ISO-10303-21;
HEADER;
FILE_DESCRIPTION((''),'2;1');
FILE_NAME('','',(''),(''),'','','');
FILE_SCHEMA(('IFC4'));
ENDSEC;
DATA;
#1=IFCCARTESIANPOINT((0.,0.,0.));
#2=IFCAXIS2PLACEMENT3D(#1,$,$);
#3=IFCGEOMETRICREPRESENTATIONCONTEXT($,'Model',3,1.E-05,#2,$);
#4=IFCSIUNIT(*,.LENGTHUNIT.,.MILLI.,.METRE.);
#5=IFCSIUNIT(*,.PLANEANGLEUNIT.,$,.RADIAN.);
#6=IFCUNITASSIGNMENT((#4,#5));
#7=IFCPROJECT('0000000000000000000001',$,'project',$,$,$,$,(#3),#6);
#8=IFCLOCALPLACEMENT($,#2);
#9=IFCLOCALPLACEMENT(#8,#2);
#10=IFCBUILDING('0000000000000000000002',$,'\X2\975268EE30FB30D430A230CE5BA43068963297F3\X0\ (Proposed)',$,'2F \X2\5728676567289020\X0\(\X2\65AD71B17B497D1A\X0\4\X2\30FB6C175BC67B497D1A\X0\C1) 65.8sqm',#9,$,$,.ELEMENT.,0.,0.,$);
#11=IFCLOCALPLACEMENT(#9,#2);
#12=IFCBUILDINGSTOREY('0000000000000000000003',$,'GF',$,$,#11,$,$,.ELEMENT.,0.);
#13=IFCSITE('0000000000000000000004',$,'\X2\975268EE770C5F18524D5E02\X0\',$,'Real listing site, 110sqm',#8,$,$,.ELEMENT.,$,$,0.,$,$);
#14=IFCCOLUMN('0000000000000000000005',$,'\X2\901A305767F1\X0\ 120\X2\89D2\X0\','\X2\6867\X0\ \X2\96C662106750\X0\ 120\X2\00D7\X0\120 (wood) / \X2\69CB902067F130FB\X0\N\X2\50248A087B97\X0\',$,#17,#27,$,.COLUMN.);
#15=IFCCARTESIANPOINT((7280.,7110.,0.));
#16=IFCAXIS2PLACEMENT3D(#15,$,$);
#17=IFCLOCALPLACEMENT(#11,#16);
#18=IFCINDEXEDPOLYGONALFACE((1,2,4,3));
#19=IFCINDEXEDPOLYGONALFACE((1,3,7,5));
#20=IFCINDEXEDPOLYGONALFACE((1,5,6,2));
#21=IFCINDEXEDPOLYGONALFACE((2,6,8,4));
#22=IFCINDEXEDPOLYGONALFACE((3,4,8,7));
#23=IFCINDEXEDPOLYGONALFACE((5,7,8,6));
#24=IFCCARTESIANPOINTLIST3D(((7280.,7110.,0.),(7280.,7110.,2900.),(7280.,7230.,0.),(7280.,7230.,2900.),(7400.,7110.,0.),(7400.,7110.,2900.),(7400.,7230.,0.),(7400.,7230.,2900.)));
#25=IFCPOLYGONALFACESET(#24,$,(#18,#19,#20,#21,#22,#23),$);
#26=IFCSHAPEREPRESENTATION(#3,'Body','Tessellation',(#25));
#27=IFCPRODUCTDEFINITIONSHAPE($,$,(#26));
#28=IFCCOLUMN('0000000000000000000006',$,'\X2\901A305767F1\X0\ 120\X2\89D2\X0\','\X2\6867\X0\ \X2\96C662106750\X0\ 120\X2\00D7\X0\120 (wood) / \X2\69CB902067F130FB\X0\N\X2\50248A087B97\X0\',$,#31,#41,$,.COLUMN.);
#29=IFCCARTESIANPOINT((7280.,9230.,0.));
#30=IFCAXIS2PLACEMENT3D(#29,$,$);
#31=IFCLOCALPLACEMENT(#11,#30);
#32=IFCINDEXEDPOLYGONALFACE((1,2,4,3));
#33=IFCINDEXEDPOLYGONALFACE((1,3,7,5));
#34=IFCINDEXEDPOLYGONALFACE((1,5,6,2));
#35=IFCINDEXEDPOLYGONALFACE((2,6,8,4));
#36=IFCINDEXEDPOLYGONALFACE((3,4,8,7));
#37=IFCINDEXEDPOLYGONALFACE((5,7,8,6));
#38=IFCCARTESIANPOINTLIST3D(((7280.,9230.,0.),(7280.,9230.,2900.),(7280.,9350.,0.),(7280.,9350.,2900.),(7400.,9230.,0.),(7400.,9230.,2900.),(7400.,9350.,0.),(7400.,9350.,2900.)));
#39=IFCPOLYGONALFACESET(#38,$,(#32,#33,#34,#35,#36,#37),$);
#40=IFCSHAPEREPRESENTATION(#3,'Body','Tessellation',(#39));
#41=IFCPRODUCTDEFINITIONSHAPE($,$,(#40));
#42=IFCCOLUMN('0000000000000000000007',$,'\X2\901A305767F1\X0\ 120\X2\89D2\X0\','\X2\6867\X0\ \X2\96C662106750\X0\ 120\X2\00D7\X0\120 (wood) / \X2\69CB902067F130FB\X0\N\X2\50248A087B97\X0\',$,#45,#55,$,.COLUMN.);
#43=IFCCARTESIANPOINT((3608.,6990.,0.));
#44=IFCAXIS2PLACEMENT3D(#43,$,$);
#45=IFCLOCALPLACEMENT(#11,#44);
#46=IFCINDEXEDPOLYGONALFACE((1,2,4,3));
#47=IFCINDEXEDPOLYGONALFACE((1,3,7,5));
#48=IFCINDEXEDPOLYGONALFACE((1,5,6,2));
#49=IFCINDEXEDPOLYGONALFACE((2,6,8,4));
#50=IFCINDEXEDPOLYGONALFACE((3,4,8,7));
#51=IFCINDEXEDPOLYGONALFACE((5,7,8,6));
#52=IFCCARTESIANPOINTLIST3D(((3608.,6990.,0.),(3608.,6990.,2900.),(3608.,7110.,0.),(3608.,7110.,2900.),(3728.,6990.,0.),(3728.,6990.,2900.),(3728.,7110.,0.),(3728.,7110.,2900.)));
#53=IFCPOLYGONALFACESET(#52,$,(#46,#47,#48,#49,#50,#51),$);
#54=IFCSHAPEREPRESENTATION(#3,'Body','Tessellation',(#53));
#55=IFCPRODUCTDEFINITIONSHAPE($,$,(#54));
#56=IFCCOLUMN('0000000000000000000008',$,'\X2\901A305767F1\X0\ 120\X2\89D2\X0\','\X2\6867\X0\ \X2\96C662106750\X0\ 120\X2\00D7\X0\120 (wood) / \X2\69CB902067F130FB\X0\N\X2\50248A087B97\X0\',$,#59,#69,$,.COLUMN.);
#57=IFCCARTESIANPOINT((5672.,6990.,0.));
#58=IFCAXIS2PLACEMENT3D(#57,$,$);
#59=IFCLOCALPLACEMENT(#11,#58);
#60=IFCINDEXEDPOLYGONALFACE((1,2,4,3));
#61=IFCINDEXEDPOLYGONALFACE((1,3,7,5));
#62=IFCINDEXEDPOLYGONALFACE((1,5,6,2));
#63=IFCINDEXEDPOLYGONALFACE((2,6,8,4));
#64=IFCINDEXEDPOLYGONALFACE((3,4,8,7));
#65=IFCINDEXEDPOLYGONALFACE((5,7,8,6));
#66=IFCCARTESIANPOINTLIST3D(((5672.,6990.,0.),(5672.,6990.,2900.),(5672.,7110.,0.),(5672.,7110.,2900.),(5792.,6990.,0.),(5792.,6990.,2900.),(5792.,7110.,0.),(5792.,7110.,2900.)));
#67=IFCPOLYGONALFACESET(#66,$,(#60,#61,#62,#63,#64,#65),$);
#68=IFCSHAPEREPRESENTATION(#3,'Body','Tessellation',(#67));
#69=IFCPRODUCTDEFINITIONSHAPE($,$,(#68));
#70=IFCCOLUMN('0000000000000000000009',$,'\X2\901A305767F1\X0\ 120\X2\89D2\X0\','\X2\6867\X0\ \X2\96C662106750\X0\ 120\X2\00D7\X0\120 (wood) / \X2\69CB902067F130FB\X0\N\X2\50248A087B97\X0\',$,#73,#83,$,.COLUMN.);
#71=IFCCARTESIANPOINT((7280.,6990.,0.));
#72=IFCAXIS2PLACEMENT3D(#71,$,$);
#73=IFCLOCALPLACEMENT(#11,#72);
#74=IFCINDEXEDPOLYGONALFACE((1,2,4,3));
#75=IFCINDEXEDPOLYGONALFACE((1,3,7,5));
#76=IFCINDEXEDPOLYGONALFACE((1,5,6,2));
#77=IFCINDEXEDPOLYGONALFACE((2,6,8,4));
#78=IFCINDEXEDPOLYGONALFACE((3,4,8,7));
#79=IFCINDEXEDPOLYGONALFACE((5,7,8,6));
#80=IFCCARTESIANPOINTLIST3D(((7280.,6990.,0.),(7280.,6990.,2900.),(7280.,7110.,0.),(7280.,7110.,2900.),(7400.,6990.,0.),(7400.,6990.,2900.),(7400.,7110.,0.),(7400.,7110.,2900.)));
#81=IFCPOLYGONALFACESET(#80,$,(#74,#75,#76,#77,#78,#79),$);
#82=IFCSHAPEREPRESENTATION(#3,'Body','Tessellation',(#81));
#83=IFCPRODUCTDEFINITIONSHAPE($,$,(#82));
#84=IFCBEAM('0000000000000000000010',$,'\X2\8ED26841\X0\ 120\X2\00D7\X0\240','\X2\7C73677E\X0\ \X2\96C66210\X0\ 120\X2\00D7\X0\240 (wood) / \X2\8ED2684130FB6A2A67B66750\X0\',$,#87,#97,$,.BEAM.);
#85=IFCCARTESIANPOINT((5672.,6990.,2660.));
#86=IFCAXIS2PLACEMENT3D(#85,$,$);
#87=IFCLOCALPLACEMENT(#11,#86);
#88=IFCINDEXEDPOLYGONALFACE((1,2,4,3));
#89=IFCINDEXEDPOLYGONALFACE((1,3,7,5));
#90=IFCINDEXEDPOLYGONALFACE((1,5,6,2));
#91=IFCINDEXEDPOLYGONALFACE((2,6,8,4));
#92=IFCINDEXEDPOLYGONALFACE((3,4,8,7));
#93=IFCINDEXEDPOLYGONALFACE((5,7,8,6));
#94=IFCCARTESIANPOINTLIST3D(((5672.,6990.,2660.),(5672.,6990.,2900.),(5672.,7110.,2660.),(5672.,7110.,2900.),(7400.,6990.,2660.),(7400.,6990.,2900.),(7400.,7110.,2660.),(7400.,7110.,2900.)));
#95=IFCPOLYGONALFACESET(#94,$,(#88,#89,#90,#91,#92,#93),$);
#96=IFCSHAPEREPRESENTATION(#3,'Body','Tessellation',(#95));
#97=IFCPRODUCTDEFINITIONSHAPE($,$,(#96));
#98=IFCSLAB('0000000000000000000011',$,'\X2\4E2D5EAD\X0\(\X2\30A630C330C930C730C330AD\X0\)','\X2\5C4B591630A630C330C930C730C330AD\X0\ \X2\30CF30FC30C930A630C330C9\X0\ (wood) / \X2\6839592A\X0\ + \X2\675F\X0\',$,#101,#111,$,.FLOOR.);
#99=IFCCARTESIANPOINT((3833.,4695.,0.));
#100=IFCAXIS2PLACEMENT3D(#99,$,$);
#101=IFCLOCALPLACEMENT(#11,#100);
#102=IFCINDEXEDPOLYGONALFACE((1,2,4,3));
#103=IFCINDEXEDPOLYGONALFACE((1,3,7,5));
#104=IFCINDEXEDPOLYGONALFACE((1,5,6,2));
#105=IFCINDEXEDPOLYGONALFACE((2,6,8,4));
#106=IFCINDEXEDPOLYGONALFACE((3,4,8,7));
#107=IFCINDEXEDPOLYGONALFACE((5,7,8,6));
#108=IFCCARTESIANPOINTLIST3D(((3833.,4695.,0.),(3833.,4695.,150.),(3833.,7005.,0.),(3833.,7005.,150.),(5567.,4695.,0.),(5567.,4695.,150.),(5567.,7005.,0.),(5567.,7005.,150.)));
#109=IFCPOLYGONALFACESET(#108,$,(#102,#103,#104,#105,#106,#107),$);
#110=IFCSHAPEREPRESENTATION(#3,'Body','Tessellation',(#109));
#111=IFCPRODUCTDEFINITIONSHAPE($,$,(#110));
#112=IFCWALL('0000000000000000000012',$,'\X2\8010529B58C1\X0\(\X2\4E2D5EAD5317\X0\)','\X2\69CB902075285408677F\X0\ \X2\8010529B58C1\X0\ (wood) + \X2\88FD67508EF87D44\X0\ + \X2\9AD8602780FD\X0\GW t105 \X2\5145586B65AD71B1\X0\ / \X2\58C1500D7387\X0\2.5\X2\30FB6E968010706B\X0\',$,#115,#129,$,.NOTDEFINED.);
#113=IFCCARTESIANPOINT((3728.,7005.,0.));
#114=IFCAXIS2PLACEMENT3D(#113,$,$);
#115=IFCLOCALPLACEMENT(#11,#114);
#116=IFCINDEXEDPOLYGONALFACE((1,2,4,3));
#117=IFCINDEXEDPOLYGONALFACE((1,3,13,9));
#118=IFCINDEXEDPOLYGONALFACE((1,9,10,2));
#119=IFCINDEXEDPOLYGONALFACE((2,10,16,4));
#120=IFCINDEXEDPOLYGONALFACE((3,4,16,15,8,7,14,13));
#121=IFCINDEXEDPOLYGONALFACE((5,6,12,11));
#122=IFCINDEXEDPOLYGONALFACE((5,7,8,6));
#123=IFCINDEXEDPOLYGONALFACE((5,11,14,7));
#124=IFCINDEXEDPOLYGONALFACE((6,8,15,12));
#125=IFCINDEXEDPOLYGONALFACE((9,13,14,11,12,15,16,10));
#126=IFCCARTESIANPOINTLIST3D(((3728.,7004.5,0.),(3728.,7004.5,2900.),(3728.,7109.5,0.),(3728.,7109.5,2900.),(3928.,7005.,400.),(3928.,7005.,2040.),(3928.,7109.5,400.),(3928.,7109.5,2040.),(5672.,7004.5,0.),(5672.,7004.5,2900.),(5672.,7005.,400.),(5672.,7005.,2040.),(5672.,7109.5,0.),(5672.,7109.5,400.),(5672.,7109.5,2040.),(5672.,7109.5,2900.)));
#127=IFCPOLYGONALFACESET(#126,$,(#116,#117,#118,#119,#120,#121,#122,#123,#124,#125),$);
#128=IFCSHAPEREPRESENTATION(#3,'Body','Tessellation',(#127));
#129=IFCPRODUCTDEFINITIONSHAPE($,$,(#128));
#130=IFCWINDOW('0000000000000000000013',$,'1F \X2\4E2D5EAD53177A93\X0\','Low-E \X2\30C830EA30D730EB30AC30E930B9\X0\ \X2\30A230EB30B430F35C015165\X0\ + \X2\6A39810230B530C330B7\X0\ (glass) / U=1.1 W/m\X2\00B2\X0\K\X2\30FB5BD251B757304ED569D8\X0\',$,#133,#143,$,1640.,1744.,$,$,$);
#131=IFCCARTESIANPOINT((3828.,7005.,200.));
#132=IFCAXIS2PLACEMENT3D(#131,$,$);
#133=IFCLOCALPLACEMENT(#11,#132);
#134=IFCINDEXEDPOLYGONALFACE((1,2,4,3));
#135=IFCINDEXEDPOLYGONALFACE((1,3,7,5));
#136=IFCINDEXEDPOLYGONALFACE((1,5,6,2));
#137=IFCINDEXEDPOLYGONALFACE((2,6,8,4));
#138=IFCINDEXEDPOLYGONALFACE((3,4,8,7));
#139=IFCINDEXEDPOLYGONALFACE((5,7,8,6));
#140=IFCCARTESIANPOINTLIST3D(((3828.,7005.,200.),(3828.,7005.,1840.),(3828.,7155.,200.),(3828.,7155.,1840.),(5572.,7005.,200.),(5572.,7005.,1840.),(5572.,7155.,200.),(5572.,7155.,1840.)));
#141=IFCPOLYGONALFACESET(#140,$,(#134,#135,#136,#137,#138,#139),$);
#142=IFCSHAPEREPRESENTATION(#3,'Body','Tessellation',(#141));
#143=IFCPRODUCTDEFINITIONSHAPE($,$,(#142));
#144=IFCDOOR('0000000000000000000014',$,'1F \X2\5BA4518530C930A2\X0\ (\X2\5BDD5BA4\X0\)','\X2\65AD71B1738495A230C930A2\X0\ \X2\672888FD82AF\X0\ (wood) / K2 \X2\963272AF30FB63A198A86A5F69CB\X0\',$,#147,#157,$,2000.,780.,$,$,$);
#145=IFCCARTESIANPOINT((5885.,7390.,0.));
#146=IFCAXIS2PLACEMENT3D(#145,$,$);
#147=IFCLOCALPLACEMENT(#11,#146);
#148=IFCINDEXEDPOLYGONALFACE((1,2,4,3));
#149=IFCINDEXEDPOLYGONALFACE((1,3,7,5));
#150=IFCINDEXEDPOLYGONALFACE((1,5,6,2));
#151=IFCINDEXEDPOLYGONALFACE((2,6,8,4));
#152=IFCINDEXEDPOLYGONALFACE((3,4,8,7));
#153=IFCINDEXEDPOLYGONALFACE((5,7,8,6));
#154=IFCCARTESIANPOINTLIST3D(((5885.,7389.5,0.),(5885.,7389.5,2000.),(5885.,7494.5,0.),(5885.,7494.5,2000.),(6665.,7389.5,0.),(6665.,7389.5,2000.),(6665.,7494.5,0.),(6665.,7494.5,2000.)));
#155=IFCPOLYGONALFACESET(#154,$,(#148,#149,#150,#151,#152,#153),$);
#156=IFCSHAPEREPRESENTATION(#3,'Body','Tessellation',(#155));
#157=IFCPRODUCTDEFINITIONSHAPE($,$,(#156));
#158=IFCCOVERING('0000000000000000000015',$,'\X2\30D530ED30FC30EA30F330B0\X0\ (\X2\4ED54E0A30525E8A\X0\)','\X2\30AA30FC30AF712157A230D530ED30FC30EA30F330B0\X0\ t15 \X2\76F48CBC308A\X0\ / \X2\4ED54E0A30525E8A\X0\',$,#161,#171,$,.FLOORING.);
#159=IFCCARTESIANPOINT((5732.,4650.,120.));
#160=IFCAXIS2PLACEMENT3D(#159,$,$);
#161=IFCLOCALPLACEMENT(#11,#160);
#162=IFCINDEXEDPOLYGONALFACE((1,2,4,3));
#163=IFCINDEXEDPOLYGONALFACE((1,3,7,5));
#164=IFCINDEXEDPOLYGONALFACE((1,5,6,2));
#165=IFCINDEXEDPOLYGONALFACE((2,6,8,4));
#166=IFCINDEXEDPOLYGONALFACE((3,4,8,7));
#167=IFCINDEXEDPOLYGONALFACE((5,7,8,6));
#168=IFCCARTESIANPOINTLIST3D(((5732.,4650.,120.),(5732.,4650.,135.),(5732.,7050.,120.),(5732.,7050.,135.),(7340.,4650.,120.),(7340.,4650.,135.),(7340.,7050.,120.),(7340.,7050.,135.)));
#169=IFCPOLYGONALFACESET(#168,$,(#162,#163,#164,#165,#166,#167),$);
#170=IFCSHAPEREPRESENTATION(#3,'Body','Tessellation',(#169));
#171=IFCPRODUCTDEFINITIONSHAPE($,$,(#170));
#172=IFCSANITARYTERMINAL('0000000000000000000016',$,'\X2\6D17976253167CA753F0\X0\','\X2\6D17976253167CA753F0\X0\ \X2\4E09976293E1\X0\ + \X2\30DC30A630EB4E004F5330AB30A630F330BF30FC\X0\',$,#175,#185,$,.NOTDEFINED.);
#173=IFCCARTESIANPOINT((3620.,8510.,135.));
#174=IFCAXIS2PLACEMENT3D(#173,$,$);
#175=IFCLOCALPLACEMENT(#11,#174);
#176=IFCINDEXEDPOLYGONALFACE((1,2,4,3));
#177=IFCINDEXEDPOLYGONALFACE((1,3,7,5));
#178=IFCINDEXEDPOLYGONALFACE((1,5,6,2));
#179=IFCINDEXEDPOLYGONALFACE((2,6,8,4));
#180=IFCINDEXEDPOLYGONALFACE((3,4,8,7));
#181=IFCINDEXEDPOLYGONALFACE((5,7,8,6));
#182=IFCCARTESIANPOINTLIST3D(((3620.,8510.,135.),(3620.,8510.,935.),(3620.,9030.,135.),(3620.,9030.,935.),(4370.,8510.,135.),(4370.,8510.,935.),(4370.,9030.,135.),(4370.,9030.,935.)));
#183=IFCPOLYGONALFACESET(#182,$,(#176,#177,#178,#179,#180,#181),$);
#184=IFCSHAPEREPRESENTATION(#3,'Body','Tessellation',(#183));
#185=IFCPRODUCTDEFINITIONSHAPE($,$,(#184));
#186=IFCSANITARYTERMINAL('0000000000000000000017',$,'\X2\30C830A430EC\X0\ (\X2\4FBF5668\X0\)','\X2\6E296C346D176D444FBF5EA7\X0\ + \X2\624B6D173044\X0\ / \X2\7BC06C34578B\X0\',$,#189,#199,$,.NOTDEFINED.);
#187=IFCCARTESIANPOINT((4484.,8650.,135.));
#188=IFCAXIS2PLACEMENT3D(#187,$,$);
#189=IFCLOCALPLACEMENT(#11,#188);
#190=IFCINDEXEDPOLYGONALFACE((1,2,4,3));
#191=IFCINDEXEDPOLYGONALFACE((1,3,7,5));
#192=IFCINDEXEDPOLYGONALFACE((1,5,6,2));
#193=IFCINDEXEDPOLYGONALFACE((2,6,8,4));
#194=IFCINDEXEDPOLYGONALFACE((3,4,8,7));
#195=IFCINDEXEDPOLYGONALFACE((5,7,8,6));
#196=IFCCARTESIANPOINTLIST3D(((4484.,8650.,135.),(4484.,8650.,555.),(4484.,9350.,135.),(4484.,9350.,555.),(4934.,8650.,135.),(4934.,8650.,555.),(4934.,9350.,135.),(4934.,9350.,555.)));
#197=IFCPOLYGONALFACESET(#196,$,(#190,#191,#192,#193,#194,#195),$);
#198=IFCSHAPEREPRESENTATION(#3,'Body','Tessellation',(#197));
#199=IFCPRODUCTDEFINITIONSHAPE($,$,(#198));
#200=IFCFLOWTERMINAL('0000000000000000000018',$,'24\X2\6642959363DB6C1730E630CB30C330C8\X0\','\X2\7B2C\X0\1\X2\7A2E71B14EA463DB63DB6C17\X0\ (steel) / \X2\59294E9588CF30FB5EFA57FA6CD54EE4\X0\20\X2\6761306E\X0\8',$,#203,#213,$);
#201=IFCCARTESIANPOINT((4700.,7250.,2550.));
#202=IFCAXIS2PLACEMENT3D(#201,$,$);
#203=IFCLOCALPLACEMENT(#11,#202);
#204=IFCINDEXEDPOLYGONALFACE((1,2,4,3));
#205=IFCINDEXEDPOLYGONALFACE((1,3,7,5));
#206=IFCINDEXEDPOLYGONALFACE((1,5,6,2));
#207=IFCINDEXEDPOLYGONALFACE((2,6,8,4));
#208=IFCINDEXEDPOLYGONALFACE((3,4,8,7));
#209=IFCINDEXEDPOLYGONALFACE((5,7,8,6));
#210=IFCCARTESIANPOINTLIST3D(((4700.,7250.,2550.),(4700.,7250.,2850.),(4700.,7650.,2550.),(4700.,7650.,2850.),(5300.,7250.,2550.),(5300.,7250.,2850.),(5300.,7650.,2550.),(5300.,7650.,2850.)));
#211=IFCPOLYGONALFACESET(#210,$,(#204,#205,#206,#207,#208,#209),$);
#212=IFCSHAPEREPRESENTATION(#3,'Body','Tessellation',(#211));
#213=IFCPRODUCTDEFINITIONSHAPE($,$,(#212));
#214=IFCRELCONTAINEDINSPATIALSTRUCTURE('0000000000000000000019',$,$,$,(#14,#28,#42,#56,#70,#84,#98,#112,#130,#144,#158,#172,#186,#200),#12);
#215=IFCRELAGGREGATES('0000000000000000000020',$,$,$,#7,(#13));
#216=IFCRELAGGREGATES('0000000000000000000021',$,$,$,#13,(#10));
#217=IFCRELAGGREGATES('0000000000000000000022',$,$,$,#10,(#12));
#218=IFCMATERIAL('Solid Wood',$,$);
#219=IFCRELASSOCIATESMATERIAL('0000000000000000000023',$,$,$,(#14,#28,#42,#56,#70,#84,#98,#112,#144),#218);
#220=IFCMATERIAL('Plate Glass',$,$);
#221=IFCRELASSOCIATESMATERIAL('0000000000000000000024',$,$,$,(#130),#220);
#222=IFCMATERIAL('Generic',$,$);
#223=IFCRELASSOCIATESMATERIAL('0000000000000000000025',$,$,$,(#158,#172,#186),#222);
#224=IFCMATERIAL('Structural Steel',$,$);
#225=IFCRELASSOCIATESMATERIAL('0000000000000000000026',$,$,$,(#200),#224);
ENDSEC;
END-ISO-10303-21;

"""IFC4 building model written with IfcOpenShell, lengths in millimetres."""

from ifc_helpers import new_model, si_unit, frame, frame_2d, origin, place, context, project, spatial, rectangle, extrude, material, element, fill, save


model = new_model("IFC4")

# Units and contexts
model_context = context("Model", 3, precision=1e-05, world=origin())
ifc_project = project(units=[si_unit("LENGTHUNIT", "METRE", prefix="MILLI"), si_unit("PLANEANGLEUNIT", "RADIAN")], contexts=[model_context])

# Site, building, storey
site_placement = place(None, origin())
site = spatial("IfcSite", under=ifc_project, at=site_placement, Name="青森県弘前市", ObjectType="Real listing site, 110sqm", CompositionType="ELEMENT", RefElevation=0.0)
building_placement = place(site_placement, origin())
building = spatial("IfcBuilding", under=site, at=building_placement, Name="青森・ピアノ室と防音 (Proposed)", ObjectType="2F 在来木造(断熱等級4・気密等級C1) 65.8sqm", CompositionType="ELEMENT", ElevationOfRefHeight=0.0, ElevationOfTerrain=0.0)
storey_placement = place(building_placement, origin())
storey = spatial("IfcBuildingStorey", under=building, at=storey_placement, Name="GF", CompositionType="ELEMENT", Elevation=0.0)

# Columns
ifc_material_1 = material(Name="Solid Wood")
column_1_placement = place(storey_placement, frame((7280.0, 7110.0, 0.0)))
element("IfcColumn", 1, at=column_1_placement, inside=storey, material=ifc_material_1, Name="通し柱 120角", Description="桧 集成材 120×120 (wood) / 構造柱・N値計算", PredefinedType="COLUMN", context=model_context, shape_type="SweptSolid", body=[
    extrude(rectangle(XDim=120.0, YDim=120.0, at=frame_2d((60.0, 60.0))), frame((7280.0, 7110.0, 0.0)), (0.0, 0.0, 1.0), 2900.0),
])
column_2_placement = place(storey_placement, frame((7280.0, 9230.0, 0.0)))
element("IfcColumn", 2, at=column_2_placement, inside=storey, material=ifc_material_1, Name="通し柱 120角", Description="桧 集成材 120×120 (wood) / 構造柱・N値計算", PredefinedType="COLUMN", context=model_context, shape_type="SweptSolid", body=[
    extrude(rectangle(XDim=120.0, YDim=120.0, at=frame_2d((60.0, 60.0))), frame((7280.0, 9230.0, 0.0)), (0.0, 0.0, 1.0), 2900.0),
])
column_3_placement = place(storey_placement, frame((3608.0, 6990.0, 0.0)))
element("IfcColumn", 3, at=column_3_placement, inside=storey, material=ifc_material_1, Name="通し柱 120角", Description="桧 集成材 120×120 (wood) / 構造柱・N値計算", PredefinedType="COLUMN", context=model_context, shape_type="SweptSolid", body=[
    extrude(rectangle(XDim=120.0, YDim=120.0, at=frame_2d((60.0, 60.0))), frame((3608.0, 6990.0, 0.0)), (0.0, 0.0, 1.0), 2900.0),
])
column_4_placement = place(storey_placement, frame((5672.0, 6990.0, 0.0)))
element("IfcColumn", 4, at=column_4_placement, inside=storey, material=ifc_material_1, Name="通し柱 120角", Description="桧 集成材 120×120 (wood) / 構造柱・N値計算", PredefinedType="COLUMN", context=model_context, shape_type="SweptSolid", body=[
    extrude(rectangle(XDim=120.0, YDim=120.0, at=frame_2d((60.0, 60.0))), frame((5672.0, 6990.0, 0.0)), (0.0, 0.0, 1.0), 2900.0),
])
column_5_placement = place(storey_placement, frame((7280.0, 6990.0, 0.0)))
element("IfcColumn", 5, at=column_5_placement, inside=storey, material=ifc_material_1, Name="通し柱 120角", Description="桧 集成材 120×120 (wood) / 構造柱・N値計算", PredefinedType="COLUMN", context=model_context, shape_type="SweptSolid", body=[
    extrude(rectangle(XDim=120.0, YDim=120.0, at=frame_2d((60.0, 60.0))), frame((7280.0, 6990.0, 0.0)), (0.0, 0.0, 1.0), 2900.0),
])

# Beam
beam_1_placement = place(storey_placement, frame((5672.0, 6990.0, 2660.0)))
element("IfcBeam", 6, at=beam_1_placement, inside=storey, material=ifc_material_1, Name="軒桁 120×240", Description="米松 集成 120×240 (wood) / 軒桁・横架材", PredefinedType="BEAM", context=model_context, shape_type="SweptSolid", body=[
    extrude(rectangle(XDim=1728.0, YDim=120.0, at=frame_2d((864.0, 60.0))), frame((5672.0, 6990.0, 2660.0)), (0.0, 0.0, 1.0), 240.0),
])

# Slab
slab_placement = place(storey_placement, frame((3833.0, 4695.0, 0.0)))
element("IfcSlab", 7, at=slab_placement, inside=storey, material=ifc_material_1, Name="中庭(ウッドデッキ)", Description="屋外ウッドデッキ ハードウッド (wood) / 根太 + 束", PredefinedType="FLOOR", context=model_context, shape_type="SweptSolid", body=[
    extrude(rectangle(XDim=1734.0, YDim=2310.0, at=frame_2d((867.0, 1155.0))), frame((3833.0, 4695.0, 0.0)), (0.0, 0.0, 1.0), 150.0),
])

# Wall, opening, window
wall_1_placement = place(storey_placement, frame((3728.0, 7005.0, 0.0)))
wall_1 = element("IfcWall", 8, at=wall_1_placement, inside=storey, material=ifc_material_1, Name="耐力壁(中庭北)", Description="構造用合板 耐力壁 (wood) + 製材軸組 + 高性能GW t105 充填断熱 / 壁倍率2.5・準耐火", PredefinedType="NOTDEFINED", context=model_context, shape_type="SweptSolid", body=[
    extrude(rectangle(XDim=1944.0, YDim=105.0, at=frame_2d((972.0, 52.0))), frame((3728.0, 7005.0, 0.0)), (0.0, 0.0, 1.0), 2900.0),
])
opening_placement = place(storey_placement, frame((3828.0, 7005.0, 200.0)))
opening = element("IfcOpeningElement", 9, at=opening_placement, cuts=wall_1, PredefinedType="NOTDEFINED", context=model_context, shape_type="SweptSolid", body=[
    extrude(rectangle(XDim=1744.0, YDim=150.0, at=frame_2d((872.0, 75.0))), frame((3828.0, 7005.0, 200.0)), (0.0, 0.0, 1.0), 1640.0),
])
ifc_material_2 = material(Name="Plate Glass")
window_placement = place(storey_placement, frame((3828.0, 7005.0, 200.0)))
window = element("IfcWindow", 10, at=window_placement, inside=storey, material=ifc_material_2, Name="1F 中庭北窓", Description="Low-E トリプルガラス アルゴン封入 + 樹脂サッシ (glass) / U=1.1 W/m²K・寒冷地仕様", OverallHeight=1640.0, OverallWidth=1744.0, context=model_context, shape_type="SweptSolid", body=[
    extrude(rectangle(XDim=1744.0, YDim=150.0, at=frame_2d((872.0, 75.0))), frame((3828.0, 7005.0, 200.0)), (0.0, 0.0, 1.0), 1640.0),
])
fill(opening, window)

# Door
door_placement = place(storey_placement, frame((5885.0, 7390.0, 0.0)))
element("IfcDoor", 11, at=door_placement, inside=storey, material=ifc_material_1, Name="1F 室内ドア (寝室)", Description="断熱玄関ドア 木製芯 (wood) / K2 防犯・採風機構", OverallHeight=2000.0, OverallWidth=780.0, context=model_context, shape_type="SweptSolid", body=[
    extrude(rectangle(XDim=780.0, YDim=105.0, at=frame_2d((390.0, 52.0))), frame((5885.0, 7390.0, 0.0)), (0.0, 0.0, 1.0), 2000.0),
])

# Covering
ifc_material_3 = material(Name="Generic")
covering_placement = place(storey_placement, frame((5732.0, 4650.0, 120.0)))
element("IfcCovering", 12, at=covering_placement, inside=storey, material=ifc_material_3, Name="フローリング (仕上げ床)", Description="オーク無垢フローリング t15 直貼り / 仕上げ床", PredefinedType="FLOORING", context=model_context, shape_type="SweptSolid", body=[
    extrude(rectangle(XDim=1608.0, YDim=2400.0, at=frame_2d((804.0, 1200.0))), frame((5732.0, 4650.0, 120.0)), (0.0, 0.0, 1.0), 15.0),
])

# Sanitary terminals
sanitary_terminal_1_placement = place(storey_placement, frame((3620.0, 8510.0, 135.0)))
element("IfcSanitaryTerminal", 13, at=sanitary_terminal_1_placement, inside=storey, material=ifc_material_3, Name="洗面化粧台", Description="洗面化粧台 三面鏡 + ボウル一体カウンター", PredefinedType="NOTDEFINED", context=model_context, shape_type="SweptSolid", body=[
    extrude(rectangle(XDim=750.0, YDim=520.0, at=frame_2d((375.0, 260.0))), frame((3620.0, 8510.0, 135.0)), (0.0, 0.0, 1.0), 800.0),
])
sanitary_terminal_2_placement = place(storey_placement, frame((4484.0, 8650.0, 135.0)))
element("IfcSanitaryTerminal", 14, at=sanitary_terminal_2_placement, inside=storey, material=ifc_material_3, Name="トイレ (便器)", Description="温水洗浄便座 + 手洗い / 節水型", PredefinedType="NOTDEFINED", context=model_context, shape_type="SweptSolid", body=[
    extrude(rectangle(XDim=450.0, YDim=700.0, at=frame_2d((225.0, 350.0))), frame((4484.0, 8650.0, 135.0)), (0.0, 0.0, 1.0), 420.0),
])

# Flow terminal
ifc_material_4 = material(Name="Structural Steel")
flow_terminal_placement = place(storey_placement, frame((4700.0, 7250.0, 2550.0)))
element("IfcFlowTerminal", 15, at=flow_terminal_placement, inside=storey, material=ifc_material_4, Name="24時間換気ユニット", Description="第1種熱交換換気 (steel) / 天井裏・建基法令20条の8", context=model_context, shape_type="SweptSolid", body=[
    extrude(rectangle(XDim=600.0, YDim=400.0, at=frame_2d((300.0, 200.0))), frame((4700.0, 7250.0, 2550.0)), (0.0, 0.0, 1.0), 300.0),
])

save(model, "model.ifc")
